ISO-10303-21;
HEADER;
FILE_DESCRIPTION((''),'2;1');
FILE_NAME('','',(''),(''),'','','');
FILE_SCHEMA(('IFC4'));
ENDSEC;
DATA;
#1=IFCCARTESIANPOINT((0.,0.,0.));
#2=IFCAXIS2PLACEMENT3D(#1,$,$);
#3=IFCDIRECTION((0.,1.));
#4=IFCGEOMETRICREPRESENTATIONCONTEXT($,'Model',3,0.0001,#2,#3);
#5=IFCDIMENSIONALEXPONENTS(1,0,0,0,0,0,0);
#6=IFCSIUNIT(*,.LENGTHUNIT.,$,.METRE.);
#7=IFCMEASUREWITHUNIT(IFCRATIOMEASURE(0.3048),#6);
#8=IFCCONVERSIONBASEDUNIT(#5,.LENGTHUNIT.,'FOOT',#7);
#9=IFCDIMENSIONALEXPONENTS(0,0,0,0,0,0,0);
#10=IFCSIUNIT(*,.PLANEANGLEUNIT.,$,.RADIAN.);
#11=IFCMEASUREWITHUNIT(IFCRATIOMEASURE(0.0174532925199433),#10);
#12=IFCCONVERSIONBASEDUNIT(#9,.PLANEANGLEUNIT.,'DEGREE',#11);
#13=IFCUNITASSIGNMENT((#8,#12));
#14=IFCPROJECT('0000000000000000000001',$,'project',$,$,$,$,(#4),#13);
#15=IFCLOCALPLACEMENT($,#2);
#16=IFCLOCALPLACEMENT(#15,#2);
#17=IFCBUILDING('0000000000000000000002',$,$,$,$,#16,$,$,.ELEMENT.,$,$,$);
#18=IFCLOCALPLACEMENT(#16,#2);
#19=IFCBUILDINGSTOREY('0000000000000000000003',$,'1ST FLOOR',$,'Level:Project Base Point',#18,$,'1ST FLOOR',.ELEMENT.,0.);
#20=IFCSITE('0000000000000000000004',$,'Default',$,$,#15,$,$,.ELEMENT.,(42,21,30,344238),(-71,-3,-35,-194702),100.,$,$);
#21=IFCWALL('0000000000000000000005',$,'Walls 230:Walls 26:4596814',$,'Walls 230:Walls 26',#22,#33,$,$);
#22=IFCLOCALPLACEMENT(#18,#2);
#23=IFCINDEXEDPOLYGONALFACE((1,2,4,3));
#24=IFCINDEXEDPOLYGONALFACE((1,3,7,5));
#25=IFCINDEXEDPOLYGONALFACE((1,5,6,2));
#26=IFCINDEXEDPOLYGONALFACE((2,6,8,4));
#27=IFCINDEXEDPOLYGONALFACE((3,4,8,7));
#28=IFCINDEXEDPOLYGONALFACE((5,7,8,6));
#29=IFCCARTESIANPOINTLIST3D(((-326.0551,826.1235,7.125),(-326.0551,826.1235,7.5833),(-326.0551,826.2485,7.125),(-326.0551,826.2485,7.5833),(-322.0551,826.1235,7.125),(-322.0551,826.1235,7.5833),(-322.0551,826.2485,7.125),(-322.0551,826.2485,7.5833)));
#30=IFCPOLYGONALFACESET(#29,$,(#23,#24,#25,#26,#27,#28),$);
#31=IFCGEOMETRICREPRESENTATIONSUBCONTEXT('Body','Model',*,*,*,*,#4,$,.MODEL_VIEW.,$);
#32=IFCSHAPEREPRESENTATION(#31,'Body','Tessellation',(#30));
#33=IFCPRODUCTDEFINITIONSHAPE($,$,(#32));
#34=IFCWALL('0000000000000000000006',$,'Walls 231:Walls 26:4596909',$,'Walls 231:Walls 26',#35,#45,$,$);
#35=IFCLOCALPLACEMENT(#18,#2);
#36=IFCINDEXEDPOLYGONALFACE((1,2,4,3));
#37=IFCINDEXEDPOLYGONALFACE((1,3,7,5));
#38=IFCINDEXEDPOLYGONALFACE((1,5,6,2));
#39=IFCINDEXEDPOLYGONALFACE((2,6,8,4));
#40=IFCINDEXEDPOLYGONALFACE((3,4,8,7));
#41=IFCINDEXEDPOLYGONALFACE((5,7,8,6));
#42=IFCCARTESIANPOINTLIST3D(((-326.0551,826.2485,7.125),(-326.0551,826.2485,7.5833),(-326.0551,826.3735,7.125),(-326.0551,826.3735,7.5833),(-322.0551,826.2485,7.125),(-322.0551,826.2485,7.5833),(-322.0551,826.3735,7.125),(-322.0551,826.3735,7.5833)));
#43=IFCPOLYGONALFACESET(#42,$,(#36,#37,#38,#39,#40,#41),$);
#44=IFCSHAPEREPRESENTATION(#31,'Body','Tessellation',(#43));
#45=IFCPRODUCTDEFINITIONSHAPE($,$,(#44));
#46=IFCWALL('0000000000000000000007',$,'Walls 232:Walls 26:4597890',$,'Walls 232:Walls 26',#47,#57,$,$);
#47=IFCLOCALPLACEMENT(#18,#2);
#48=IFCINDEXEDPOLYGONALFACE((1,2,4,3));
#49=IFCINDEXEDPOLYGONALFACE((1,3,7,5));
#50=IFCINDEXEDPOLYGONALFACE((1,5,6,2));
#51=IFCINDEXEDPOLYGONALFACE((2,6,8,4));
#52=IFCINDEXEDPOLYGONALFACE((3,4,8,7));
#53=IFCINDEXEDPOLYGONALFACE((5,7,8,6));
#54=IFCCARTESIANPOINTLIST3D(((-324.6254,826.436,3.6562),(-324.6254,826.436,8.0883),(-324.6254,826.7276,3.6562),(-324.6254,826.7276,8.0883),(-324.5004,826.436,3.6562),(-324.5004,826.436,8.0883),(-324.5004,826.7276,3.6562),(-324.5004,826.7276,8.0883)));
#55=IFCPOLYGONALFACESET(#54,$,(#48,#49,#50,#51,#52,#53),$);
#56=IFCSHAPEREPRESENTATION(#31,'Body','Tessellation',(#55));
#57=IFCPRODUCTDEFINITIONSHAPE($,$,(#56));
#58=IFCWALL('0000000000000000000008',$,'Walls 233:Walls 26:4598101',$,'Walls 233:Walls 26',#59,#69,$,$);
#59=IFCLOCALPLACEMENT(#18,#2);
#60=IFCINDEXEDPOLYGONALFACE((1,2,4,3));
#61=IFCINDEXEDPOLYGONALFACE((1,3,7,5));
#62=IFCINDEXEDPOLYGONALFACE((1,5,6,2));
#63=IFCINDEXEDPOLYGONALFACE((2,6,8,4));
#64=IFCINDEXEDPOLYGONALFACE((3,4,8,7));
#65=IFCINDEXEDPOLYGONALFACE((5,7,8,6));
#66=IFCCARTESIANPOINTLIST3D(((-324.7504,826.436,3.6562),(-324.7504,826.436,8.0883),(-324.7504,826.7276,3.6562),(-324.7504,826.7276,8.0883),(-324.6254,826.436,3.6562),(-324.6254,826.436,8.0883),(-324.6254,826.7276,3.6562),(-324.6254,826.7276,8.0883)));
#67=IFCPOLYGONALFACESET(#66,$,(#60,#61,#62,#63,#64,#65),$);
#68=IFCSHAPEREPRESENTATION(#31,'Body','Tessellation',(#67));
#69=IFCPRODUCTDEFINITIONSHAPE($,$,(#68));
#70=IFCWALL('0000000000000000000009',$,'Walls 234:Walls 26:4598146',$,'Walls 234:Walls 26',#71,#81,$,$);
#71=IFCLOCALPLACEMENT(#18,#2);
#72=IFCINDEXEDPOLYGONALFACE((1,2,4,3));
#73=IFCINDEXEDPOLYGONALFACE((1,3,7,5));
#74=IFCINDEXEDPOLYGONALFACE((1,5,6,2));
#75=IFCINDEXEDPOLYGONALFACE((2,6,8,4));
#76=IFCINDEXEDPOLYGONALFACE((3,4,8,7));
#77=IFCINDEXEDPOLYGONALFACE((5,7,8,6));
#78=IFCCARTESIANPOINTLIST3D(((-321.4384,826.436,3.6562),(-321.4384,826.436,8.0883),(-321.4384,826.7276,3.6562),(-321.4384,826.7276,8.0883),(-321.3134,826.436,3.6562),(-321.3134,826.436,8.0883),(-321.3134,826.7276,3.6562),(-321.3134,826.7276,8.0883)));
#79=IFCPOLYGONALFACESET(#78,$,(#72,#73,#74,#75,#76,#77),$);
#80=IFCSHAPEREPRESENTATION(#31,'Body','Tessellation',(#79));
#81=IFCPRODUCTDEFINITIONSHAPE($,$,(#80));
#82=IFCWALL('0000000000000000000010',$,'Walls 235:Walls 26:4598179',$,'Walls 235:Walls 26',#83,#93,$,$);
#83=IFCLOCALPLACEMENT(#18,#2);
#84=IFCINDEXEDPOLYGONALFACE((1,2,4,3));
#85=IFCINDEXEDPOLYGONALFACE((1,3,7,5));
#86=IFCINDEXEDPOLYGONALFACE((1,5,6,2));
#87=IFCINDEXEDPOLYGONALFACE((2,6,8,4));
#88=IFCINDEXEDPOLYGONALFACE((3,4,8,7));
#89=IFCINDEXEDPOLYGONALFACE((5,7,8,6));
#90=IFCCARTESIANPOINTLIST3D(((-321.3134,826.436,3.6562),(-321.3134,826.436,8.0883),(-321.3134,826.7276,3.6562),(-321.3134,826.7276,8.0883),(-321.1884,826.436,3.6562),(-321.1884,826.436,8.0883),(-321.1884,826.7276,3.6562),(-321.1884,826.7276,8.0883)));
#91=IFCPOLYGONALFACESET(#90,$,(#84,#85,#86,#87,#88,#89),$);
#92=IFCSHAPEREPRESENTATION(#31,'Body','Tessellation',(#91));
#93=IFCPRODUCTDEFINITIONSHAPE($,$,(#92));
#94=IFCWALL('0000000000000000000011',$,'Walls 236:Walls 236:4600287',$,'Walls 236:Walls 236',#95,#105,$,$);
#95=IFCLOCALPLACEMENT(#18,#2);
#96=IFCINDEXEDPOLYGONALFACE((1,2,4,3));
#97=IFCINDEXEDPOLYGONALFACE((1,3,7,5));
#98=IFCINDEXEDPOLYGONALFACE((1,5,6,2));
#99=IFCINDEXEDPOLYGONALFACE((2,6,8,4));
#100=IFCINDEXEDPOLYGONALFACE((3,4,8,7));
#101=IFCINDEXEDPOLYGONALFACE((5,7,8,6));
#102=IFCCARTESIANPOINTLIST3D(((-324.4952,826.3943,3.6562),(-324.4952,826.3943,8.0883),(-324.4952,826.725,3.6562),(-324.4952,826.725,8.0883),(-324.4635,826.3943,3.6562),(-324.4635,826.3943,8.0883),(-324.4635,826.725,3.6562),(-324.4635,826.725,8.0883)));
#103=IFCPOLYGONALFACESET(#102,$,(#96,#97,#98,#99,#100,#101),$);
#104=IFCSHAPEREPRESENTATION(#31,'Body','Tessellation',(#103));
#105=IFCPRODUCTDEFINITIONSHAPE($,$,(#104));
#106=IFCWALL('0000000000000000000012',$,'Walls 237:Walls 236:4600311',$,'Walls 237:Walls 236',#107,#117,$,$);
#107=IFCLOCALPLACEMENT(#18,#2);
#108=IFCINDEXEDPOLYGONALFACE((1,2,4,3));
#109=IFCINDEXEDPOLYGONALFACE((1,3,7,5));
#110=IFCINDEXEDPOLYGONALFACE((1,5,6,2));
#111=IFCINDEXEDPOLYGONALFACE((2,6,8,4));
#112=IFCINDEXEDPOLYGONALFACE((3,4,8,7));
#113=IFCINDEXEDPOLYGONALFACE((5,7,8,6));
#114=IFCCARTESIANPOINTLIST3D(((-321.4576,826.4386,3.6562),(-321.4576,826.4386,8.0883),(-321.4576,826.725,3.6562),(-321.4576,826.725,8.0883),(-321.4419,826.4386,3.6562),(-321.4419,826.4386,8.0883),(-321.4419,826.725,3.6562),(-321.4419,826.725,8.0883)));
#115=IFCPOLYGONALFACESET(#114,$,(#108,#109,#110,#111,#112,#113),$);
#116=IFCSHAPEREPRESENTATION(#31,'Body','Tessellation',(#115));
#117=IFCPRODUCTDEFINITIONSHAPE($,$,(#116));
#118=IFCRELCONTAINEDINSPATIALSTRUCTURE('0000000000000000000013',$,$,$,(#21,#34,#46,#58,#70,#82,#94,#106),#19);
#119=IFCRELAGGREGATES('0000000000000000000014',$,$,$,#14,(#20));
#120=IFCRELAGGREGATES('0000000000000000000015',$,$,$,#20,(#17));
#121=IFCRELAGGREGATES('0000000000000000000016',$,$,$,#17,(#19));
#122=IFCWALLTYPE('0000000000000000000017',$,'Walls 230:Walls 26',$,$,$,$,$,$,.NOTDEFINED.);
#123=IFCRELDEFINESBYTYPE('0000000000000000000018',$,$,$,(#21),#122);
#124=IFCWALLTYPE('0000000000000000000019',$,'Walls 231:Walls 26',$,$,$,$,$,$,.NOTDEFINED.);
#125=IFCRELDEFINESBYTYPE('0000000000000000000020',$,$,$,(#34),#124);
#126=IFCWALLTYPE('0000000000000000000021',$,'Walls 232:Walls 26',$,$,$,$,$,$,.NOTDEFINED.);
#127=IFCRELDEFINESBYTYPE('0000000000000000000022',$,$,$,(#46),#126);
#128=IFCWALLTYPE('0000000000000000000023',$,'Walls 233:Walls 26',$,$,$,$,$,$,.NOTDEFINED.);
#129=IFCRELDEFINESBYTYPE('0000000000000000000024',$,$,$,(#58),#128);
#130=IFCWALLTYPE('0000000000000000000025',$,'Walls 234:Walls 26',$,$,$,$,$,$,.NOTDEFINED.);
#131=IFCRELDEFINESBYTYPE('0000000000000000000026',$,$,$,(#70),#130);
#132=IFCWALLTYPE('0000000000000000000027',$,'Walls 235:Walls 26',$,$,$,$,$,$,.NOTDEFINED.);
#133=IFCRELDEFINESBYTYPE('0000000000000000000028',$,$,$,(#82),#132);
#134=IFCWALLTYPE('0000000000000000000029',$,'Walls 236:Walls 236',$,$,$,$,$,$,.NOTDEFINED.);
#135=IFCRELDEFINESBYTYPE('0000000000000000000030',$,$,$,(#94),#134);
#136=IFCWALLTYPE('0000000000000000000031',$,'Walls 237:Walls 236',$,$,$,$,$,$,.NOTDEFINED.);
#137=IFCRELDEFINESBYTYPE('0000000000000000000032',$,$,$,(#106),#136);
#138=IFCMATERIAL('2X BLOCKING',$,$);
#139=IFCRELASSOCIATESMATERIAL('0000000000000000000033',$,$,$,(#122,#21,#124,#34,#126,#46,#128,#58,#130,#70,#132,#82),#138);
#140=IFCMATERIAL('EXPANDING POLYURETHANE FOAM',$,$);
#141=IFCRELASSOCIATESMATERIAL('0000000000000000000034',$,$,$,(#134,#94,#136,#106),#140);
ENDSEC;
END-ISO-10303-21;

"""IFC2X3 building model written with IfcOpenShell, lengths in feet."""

from ifc_helpers import new_model, entity, si_unit, converted_unit, direction, frame, frame_2d, origin, origin_2d_with_axis, place, context, subcontext, project, spatial, rectangle, extrude, material, type_object, element, save


model = new_model("IFC2X3")

# Units and contexts
model_context = context("Model", 3, precision=0.0001, world=origin(), true_north=direction((0.0, 1.0)))
body_context = subcontext(model_context, "Body", "Model", "MODEL_VIEW")
ifc_project = project(units=[converted_unit("LENGTHUNIT", "FOOT", entity("IfcRatioMeasure", 0.3048), si_unit("LENGTHUNIT", "METRE"), dimensions=[1, 0, 0, 0, 0, 0, 0]), converted_unit("PLANEANGLEUNIT", "DEGREE", entity("IfcRatioMeasure", 0.0174532925199433), si_unit("PLANEANGLEUNIT", "RADIAN"), dimensions=[0, 0, 0, 0, 0, 0, 0])], contexts=[model_context])

# Site, building, storey
site_placement = place(None, origin())
site = spatial("IfcSite", under=ifc_project, at=site_placement, Name="Default", CompositionType="ELEMENT", RefLatitude=(42, 21, 30, 344238), RefLongitude=(-71, -3, -35, -194702), RefElevation=100.0)
building_placement = place(site_placement, origin())
building = spatial("IfcBuilding", under=site, at=building_placement, CompositionType="ELEMENT")
storey_placement = place(building_placement, origin())
storey = spatial("IfcBuildingStorey", under=building, at=storey_placement, Name="1ST FLOOR", ObjectType="Level:Project Base Point", LongName="1ST FLOOR", CompositionType="ELEMENT", Elevation=0.0)

# Shared definitions
ifc_material_1 = material(Name="2X BLOCKING")
ifc_material_2 = material(Name="EXPANDING POLYURETHANE FOAM")

# Walls
wall_type_1 = type_object("IfcWallType", Name="Walls 230:Walls 26", PredefinedType="NOTDEFINED", material=ifc_material_1)
wall_1_placement = place(storey_placement, frame((-326.0551, 826.1235, 7.125)))
element("IfcWall", 1, at=wall_1_placement, inside=storey, type_object=wall_type_1, material=ifc_material_1, Name="Walls 230:Walls 26:4596814", ObjectType="Walls 230:Walls 26", context=body_context, shape_type="SweptSolid", body=[
    extrude(rectangle(XDim=4.0, YDim=0.125, at=origin_2d_with_axis()), frame((2.0, 0.0625, 0.0), z_axis=(0.0, 0.0, 1.0), x_axis=(-1.0, 0.0, 0.0)), (0.0, 0.0, 1.0), 0.4583),
])
wall_type_2 = type_object("IfcWallType", Name="Walls 231:Walls 26", PredefinedType="NOTDEFINED", material=ifc_material_1)
wall_2_placement = place(storey_placement, frame((-326.0551, 826.2485, 7.125)))
element("IfcWall", 2, at=wall_2_placement, inside=storey, type_object=wall_type_2, material=ifc_material_1, Name="Walls 231:Walls 26:4596909", ObjectType="Walls 231:Walls 26", context=body_context, shape_type="SweptSolid", body=[
    extrude(rectangle(XDim=4.0, YDim=0.125, at=origin_2d_with_axis()), frame((2.0, 0.0625, 0.0), z_axis=(0.0, 0.0, 1.0), x_axis=(-1.0, 0.0, 0.0)), (0.0, 0.0, 1.0), 0.4583),
])
wall_type_3 = type_object("IfcWallType", Name="Walls 232:Walls 26", PredefinedType="NOTDEFINED", material=ifc_material_1)
wall_3_placement = place(storey_placement, frame((-324.6254, 826.436, 3.6562), z_axis=(0.0, 0.0, 1.0), x_axis=(0.0, 1.0, 0.0)))
element("IfcWall", 3, at=wall_3_placement, inside=storey, type_object=wall_type_3, material=ifc_material_1, Name="Walls 232:Walls 26:4597890", ObjectType="Walls 232:Walls 26", context=body_context, shape_type="SweptSolid", body=[
    extrude(rectangle(XDim=0.125, YDim=0.2917, at=frame_2d((0.0, 0.0), x_axis=(1.0, 0.0))), frame((0.1458, -0.0625, 0.0), z_axis=(0.0, 0.0, 1.0), x_axis=(0.0, 1.0, 0.0)), (0.0, 0.0, 1.0), 4.4321),
])
wall_type_4 = type_object("IfcWallType", Name="Walls 233:Walls 26", PredefinedType="NOTDEFINED", material=ifc_material_1)
wall_4_placement = place(storey_placement, frame((-324.7504, 826.436, 3.6562), z_axis=(0.0, 0.0, 1.0), x_axis=(0.0, 1.0, 0.0)))
element("IfcWall", 4, at=wall_4_placement, inside=storey, type_object=wall_type_4, material=ifc_material_1, Name="Walls 233:Walls 26:4598101", ObjectType="Walls 233:Walls 26", context=body_context, shape_type="SweptSolid", body=[
    extrude(rectangle(XDim=0.125, YDim=0.2917, at=frame_2d((0.0, 0.0), x_axis=(1.0, 0.0))), frame((0.1458, -0.0625, 0.0), z_axis=(0.0, 0.0, 1.0), x_axis=(0.0, 1.0, 0.0)), (0.0, 0.0, 1.0), 4.4321),
])
wall_type_5 = type_object("IfcWallType", Name="Walls 234:Walls 26", PredefinedType="NOTDEFINED", material=ifc_material_1)
wall_5_placement = place(storey_placement, frame((-321.4384, 826.436, 3.6562), z_axis=(0.0, 0.0, 1.0), x_axis=(0.0, 1.0, 0.0)))
element("IfcWall", 5, at=wall_5_placement, inside=storey, type_object=wall_type_5, material=ifc_material_1, Name="Walls 234:Walls 26:4598146", ObjectType="Walls 234:Walls 26", context=body_context, shape_type="SweptSolid", body=[
    extrude(rectangle(XDim=0.125, YDim=0.2917, at=origin_2d_with_axis()), frame((0.1458, -0.0625, 0.0), z_axis=(0.0, 0.0, 1.0), x_axis=(0.0, 1.0, 0.0)), (0.0, 0.0, 1.0), 4.4321),
])
wall_type_6 = type_object("IfcWallType", Name="Walls 235:Walls 26", PredefinedType="NOTDEFINED", material=ifc_material_1)
wall_6_placement = place(storey_placement, frame((-321.3134, 826.436, 3.6562), z_axis=(0.0, 0.0, 1.0), x_axis=(0.0, 1.0, 0.0)))
element("IfcWall", 6, at=wall_6_placement, inside=storey, type_object=wall_type_6, material=ifc_material_1, Name="Walls 235:Walls 26:4598179", ObjectType="Walls 235:Walls 26", context=body_context, shape_type="SweptSolid", body=[
    extrude(rectangle(XDim=0.125, YDim=0.2917, at=origin_2d_with_axis()), frame((0.1458, -0.0625, 0.0), z_axis=(0.0, 0.0, 1.0), x_axis=(0.0, 1.0, 0.0)), (0.0, 0.0, 1.0), 4.4321),
])
wall_type_7 = type_object("IfcWallType", Name="Walls 236:Walls 236", PredefinedType="NOTDEFINED", material=ifc_material_2)
wall_7_placement = place(storey_placement, frame((-324.4952, 826.3943, 3.6562), z_axis=(0.0, 0.0, 1.0), x_axis=(0.0, 1.0, 0.0)))
element("IfcWall", 7, at=wall_7_placement, inside=storey, type_object=wall_type_7, material=ifc_material_2, Name="Walls 236:Walls 236:4600287", ObjectType="Walls 236:Walls 236", context=body_context, shape_type="SweptSolid", body=[
    extrude(rectangle(XDim=0.0317, YDim=0.3307, at=frame_2d((0.0, 0.0), x_axis=(1.0, 0.0))), frame((0.1654, -0.0159, 0.0), z_axis=(0.0, 0.0, 1.0), x_axis=(0.0, 1.0, 0.0)), (0.0, 0.0, 1.0), 4.4321),
])
wall_type_8 = type_object("IfcWallType", Name="Walls 237:Walls 236", PredefinedType="NOTDEFINED", material=ifc_material_2)
wall_8_placement = place(storey_placement, frame((-321.4576, 826.4386, 3.6562), z_axis=(0.0, 0.0, 1.0), x_axis=(0.0, 1.0, 0.0)))
element("IfcWall", 8, at=wall_8_placement, inside=storey, type_object=wall_type_8, material=ifc_material_2, Name="Walls 237:Walls 236:4600311", ObjectType="Walls 237:Walls 236", context=body_context, shape_type="SweptSolid", body=[
    extrude(rectangle(XDim=0.0156, YDim=0.2865, at=frame_2d((0.0, 0.0), x_axis=(1.0, 0.0))), frame((0.1432, -0.0078, 0.0), z_axis=(0.0, 0.0, 1.0), x_axis=(0.0, -1.0, 0.0)), (0.0, 0.0, 1.0), 4.4321),
])

save(model, "model.ifc")
